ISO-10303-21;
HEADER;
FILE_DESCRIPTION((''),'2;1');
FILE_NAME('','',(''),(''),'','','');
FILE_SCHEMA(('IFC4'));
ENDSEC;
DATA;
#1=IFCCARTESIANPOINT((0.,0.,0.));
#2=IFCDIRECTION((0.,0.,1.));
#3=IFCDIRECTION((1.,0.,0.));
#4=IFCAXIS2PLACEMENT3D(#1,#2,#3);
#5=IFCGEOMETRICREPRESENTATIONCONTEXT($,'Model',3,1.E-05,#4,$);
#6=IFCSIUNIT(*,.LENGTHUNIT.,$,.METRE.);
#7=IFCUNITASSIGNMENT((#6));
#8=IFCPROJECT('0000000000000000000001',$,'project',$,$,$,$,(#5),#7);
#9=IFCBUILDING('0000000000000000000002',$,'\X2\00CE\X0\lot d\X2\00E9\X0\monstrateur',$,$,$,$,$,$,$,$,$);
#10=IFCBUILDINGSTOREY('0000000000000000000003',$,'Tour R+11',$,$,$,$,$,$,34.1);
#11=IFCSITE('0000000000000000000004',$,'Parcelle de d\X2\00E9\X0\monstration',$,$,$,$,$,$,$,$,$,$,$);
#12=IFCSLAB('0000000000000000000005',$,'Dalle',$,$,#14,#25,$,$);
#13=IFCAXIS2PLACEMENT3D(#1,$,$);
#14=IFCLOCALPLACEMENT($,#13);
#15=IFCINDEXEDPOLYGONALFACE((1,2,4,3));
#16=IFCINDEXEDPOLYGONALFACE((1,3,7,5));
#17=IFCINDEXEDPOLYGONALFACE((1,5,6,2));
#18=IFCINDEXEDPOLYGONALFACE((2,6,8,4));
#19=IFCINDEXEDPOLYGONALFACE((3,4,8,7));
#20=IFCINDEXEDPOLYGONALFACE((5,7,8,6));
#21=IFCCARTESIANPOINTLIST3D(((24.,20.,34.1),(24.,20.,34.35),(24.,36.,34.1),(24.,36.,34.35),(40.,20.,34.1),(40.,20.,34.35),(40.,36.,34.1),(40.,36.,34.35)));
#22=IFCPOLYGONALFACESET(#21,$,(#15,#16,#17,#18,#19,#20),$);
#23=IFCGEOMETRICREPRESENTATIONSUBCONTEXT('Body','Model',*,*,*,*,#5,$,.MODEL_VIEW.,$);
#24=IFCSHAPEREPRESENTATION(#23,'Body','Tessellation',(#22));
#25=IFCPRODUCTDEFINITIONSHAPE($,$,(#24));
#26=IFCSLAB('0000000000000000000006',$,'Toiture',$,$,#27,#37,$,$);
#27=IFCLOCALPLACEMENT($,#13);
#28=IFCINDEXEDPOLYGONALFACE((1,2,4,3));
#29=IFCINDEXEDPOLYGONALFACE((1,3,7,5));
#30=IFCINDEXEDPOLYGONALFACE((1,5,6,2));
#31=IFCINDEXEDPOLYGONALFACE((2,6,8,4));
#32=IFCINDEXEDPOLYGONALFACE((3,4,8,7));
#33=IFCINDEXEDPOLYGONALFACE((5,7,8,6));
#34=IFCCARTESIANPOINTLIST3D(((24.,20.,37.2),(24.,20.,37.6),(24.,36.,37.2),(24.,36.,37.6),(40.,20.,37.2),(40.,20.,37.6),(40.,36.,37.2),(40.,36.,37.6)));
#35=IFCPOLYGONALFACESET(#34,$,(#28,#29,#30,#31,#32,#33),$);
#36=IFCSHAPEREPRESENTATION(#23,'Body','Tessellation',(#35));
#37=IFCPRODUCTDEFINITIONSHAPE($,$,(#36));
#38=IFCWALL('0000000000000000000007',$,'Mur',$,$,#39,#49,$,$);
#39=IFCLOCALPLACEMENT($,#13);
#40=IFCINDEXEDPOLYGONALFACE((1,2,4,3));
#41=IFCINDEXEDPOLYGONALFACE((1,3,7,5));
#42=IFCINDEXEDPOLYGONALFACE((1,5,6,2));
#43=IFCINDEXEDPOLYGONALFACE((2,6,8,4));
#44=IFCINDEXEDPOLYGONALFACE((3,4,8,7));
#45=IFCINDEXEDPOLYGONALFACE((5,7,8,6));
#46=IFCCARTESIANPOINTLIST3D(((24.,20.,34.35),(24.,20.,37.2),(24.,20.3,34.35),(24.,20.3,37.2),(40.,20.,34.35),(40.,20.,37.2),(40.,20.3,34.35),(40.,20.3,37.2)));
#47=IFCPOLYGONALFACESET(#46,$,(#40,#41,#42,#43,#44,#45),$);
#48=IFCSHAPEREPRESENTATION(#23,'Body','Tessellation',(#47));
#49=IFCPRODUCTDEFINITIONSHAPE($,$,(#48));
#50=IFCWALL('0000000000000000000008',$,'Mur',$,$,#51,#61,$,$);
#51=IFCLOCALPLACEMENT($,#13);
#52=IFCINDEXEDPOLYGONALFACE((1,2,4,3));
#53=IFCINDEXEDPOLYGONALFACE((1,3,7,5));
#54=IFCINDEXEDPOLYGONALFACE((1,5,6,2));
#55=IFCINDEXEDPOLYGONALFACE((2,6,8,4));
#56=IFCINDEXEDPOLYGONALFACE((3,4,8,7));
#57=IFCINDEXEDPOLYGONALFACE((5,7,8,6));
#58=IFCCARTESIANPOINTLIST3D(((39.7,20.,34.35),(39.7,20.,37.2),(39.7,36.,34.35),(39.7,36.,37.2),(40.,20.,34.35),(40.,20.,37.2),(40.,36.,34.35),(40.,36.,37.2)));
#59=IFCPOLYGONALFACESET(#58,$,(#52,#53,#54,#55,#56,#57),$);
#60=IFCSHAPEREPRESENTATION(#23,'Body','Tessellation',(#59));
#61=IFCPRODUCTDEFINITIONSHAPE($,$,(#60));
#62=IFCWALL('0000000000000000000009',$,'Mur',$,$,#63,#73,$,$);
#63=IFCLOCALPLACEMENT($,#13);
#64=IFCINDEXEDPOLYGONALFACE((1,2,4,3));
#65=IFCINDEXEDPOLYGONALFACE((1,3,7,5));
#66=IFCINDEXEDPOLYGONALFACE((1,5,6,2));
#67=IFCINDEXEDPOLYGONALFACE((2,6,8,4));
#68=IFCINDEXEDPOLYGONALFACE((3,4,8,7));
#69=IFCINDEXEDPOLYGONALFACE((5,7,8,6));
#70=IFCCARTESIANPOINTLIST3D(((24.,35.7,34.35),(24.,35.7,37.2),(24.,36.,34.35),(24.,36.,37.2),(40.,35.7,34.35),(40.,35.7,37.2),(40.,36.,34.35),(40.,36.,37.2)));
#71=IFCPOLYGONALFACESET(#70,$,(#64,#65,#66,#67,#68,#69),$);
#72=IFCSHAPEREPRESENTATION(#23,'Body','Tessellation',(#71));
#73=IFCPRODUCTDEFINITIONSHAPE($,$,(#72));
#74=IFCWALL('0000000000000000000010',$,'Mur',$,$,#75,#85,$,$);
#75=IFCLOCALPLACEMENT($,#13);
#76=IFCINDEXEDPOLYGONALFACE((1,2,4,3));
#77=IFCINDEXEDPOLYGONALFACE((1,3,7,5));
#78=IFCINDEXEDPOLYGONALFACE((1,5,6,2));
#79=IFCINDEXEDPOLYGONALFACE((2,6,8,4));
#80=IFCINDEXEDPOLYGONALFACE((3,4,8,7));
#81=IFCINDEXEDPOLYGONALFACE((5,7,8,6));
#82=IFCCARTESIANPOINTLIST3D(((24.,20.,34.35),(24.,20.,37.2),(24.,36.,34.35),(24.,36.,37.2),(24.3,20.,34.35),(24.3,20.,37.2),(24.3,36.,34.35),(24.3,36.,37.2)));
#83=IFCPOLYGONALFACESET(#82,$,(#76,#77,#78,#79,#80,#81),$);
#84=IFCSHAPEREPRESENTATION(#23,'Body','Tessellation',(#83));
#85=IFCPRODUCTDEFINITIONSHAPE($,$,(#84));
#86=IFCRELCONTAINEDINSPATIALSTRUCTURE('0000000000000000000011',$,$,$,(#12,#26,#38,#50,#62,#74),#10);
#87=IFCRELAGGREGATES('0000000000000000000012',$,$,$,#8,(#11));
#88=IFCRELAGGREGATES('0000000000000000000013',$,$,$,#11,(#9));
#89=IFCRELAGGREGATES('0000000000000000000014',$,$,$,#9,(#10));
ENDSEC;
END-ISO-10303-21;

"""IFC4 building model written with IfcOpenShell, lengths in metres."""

from ifc_helpers import new_model, si_unit, frame, origin_with_axes, place, context, subcontext, project, spatial, indexed_curve, outline, extrude, element, save


model = new_model("IFC4")

# Units and contexts
model_context = context("Model", 3, precision=1e-05, world=origin_with_axes())
body_context = subcontext(model_context, "Body", "Model", "MODEL_VIEW")
ifc_project = project(units=[si_unit("LENGTHUNIT", "METRE")], contexts=[model_context])

# Site, building, storey
site = spatial("IfcSite", under=ifc_project, Name="Parcelle de démonstration")
building = spatial("IfcBuilding", under=site, Name="Îlot démonstrateur")
storey = spatial("IfcBuildingStorey", under=building, Name="Tour R+11", Elevation=34.1)

# Slabs
slab_1_placement = place(None, frame((0.0, 0.0, 34.1), z_axis=(0.0, 0.0, 1.0), x_axis=(1.0, 0.0, 0.0)))
element("IfcSlab", 1, at=slab_1_placement, inside=storey, Name="Dalle", context=body_context, shape_type="SweptSolid", body=[
    extrude(outline(indexed_curve([(24.0, 20.0), (40.0, 20.0), (40.0, 36.0), (24.0, 36.0)])), None, (0.0, 0.0, 1.0), 0.25),
])
slab_2_placement = place(None, frame((0.0, 0.0, 37.2), z_axis=(0.0, 0.0, 1.0), x_axis=(1.0, 0.0, 0.0)))
element("IfcSlab", 2, at=slab_2_placement, inside=storey, Name="Toiture", context=body_context, shape_type="SweptSolid", body=[
    extrude(outline(indexed_curve([(24.0, 20.0), (40.0, 20.0), (40.0, 36.0), (24.0, 36.0)])), None, (0.0, 0.0, 1.0), 0.4),
])

# Walls
for number, where, z_axis, x_axis, name in (
    (3, (24.0, 20.0, 34.35), (0.0, 0.0, 1.0), (1.0, 0.0, 0.0), "Mur"),
    (4, (40.0, 20.0, 34.35), (0.0, 0.0, 1.0), (0.0, 1.0, 0.0), "Mur"),
    (5, (40.0, 36.0, 34.35), (0.0, 0.0, 1.0), (-1.0, 0.0, 0.0), "Mur"),
    (6, (24.0, 36.0, 34.35), (0.0, 0.0, 1.0), (0.0, -1.0, 0.0), "Mur"),
):
    element("IfcWall", number, at=place(None, frame(where, z_axis=z_axis, x_axis=x_axis)), inside=storey, Name=name, context=body_context, shape_type="SweptSolid", body=[
        extrude(outline(indexed_curve([(0.0, 0.0), (0.0, 0.3), (16.0, 0.3), (16.0, 0.0), (0.0, 0.0)], self_intersect=False)), origin_with_axes(), (0.0, 0.0, 1.0), 2.85),
    ])

save(model, "model.ifc")
